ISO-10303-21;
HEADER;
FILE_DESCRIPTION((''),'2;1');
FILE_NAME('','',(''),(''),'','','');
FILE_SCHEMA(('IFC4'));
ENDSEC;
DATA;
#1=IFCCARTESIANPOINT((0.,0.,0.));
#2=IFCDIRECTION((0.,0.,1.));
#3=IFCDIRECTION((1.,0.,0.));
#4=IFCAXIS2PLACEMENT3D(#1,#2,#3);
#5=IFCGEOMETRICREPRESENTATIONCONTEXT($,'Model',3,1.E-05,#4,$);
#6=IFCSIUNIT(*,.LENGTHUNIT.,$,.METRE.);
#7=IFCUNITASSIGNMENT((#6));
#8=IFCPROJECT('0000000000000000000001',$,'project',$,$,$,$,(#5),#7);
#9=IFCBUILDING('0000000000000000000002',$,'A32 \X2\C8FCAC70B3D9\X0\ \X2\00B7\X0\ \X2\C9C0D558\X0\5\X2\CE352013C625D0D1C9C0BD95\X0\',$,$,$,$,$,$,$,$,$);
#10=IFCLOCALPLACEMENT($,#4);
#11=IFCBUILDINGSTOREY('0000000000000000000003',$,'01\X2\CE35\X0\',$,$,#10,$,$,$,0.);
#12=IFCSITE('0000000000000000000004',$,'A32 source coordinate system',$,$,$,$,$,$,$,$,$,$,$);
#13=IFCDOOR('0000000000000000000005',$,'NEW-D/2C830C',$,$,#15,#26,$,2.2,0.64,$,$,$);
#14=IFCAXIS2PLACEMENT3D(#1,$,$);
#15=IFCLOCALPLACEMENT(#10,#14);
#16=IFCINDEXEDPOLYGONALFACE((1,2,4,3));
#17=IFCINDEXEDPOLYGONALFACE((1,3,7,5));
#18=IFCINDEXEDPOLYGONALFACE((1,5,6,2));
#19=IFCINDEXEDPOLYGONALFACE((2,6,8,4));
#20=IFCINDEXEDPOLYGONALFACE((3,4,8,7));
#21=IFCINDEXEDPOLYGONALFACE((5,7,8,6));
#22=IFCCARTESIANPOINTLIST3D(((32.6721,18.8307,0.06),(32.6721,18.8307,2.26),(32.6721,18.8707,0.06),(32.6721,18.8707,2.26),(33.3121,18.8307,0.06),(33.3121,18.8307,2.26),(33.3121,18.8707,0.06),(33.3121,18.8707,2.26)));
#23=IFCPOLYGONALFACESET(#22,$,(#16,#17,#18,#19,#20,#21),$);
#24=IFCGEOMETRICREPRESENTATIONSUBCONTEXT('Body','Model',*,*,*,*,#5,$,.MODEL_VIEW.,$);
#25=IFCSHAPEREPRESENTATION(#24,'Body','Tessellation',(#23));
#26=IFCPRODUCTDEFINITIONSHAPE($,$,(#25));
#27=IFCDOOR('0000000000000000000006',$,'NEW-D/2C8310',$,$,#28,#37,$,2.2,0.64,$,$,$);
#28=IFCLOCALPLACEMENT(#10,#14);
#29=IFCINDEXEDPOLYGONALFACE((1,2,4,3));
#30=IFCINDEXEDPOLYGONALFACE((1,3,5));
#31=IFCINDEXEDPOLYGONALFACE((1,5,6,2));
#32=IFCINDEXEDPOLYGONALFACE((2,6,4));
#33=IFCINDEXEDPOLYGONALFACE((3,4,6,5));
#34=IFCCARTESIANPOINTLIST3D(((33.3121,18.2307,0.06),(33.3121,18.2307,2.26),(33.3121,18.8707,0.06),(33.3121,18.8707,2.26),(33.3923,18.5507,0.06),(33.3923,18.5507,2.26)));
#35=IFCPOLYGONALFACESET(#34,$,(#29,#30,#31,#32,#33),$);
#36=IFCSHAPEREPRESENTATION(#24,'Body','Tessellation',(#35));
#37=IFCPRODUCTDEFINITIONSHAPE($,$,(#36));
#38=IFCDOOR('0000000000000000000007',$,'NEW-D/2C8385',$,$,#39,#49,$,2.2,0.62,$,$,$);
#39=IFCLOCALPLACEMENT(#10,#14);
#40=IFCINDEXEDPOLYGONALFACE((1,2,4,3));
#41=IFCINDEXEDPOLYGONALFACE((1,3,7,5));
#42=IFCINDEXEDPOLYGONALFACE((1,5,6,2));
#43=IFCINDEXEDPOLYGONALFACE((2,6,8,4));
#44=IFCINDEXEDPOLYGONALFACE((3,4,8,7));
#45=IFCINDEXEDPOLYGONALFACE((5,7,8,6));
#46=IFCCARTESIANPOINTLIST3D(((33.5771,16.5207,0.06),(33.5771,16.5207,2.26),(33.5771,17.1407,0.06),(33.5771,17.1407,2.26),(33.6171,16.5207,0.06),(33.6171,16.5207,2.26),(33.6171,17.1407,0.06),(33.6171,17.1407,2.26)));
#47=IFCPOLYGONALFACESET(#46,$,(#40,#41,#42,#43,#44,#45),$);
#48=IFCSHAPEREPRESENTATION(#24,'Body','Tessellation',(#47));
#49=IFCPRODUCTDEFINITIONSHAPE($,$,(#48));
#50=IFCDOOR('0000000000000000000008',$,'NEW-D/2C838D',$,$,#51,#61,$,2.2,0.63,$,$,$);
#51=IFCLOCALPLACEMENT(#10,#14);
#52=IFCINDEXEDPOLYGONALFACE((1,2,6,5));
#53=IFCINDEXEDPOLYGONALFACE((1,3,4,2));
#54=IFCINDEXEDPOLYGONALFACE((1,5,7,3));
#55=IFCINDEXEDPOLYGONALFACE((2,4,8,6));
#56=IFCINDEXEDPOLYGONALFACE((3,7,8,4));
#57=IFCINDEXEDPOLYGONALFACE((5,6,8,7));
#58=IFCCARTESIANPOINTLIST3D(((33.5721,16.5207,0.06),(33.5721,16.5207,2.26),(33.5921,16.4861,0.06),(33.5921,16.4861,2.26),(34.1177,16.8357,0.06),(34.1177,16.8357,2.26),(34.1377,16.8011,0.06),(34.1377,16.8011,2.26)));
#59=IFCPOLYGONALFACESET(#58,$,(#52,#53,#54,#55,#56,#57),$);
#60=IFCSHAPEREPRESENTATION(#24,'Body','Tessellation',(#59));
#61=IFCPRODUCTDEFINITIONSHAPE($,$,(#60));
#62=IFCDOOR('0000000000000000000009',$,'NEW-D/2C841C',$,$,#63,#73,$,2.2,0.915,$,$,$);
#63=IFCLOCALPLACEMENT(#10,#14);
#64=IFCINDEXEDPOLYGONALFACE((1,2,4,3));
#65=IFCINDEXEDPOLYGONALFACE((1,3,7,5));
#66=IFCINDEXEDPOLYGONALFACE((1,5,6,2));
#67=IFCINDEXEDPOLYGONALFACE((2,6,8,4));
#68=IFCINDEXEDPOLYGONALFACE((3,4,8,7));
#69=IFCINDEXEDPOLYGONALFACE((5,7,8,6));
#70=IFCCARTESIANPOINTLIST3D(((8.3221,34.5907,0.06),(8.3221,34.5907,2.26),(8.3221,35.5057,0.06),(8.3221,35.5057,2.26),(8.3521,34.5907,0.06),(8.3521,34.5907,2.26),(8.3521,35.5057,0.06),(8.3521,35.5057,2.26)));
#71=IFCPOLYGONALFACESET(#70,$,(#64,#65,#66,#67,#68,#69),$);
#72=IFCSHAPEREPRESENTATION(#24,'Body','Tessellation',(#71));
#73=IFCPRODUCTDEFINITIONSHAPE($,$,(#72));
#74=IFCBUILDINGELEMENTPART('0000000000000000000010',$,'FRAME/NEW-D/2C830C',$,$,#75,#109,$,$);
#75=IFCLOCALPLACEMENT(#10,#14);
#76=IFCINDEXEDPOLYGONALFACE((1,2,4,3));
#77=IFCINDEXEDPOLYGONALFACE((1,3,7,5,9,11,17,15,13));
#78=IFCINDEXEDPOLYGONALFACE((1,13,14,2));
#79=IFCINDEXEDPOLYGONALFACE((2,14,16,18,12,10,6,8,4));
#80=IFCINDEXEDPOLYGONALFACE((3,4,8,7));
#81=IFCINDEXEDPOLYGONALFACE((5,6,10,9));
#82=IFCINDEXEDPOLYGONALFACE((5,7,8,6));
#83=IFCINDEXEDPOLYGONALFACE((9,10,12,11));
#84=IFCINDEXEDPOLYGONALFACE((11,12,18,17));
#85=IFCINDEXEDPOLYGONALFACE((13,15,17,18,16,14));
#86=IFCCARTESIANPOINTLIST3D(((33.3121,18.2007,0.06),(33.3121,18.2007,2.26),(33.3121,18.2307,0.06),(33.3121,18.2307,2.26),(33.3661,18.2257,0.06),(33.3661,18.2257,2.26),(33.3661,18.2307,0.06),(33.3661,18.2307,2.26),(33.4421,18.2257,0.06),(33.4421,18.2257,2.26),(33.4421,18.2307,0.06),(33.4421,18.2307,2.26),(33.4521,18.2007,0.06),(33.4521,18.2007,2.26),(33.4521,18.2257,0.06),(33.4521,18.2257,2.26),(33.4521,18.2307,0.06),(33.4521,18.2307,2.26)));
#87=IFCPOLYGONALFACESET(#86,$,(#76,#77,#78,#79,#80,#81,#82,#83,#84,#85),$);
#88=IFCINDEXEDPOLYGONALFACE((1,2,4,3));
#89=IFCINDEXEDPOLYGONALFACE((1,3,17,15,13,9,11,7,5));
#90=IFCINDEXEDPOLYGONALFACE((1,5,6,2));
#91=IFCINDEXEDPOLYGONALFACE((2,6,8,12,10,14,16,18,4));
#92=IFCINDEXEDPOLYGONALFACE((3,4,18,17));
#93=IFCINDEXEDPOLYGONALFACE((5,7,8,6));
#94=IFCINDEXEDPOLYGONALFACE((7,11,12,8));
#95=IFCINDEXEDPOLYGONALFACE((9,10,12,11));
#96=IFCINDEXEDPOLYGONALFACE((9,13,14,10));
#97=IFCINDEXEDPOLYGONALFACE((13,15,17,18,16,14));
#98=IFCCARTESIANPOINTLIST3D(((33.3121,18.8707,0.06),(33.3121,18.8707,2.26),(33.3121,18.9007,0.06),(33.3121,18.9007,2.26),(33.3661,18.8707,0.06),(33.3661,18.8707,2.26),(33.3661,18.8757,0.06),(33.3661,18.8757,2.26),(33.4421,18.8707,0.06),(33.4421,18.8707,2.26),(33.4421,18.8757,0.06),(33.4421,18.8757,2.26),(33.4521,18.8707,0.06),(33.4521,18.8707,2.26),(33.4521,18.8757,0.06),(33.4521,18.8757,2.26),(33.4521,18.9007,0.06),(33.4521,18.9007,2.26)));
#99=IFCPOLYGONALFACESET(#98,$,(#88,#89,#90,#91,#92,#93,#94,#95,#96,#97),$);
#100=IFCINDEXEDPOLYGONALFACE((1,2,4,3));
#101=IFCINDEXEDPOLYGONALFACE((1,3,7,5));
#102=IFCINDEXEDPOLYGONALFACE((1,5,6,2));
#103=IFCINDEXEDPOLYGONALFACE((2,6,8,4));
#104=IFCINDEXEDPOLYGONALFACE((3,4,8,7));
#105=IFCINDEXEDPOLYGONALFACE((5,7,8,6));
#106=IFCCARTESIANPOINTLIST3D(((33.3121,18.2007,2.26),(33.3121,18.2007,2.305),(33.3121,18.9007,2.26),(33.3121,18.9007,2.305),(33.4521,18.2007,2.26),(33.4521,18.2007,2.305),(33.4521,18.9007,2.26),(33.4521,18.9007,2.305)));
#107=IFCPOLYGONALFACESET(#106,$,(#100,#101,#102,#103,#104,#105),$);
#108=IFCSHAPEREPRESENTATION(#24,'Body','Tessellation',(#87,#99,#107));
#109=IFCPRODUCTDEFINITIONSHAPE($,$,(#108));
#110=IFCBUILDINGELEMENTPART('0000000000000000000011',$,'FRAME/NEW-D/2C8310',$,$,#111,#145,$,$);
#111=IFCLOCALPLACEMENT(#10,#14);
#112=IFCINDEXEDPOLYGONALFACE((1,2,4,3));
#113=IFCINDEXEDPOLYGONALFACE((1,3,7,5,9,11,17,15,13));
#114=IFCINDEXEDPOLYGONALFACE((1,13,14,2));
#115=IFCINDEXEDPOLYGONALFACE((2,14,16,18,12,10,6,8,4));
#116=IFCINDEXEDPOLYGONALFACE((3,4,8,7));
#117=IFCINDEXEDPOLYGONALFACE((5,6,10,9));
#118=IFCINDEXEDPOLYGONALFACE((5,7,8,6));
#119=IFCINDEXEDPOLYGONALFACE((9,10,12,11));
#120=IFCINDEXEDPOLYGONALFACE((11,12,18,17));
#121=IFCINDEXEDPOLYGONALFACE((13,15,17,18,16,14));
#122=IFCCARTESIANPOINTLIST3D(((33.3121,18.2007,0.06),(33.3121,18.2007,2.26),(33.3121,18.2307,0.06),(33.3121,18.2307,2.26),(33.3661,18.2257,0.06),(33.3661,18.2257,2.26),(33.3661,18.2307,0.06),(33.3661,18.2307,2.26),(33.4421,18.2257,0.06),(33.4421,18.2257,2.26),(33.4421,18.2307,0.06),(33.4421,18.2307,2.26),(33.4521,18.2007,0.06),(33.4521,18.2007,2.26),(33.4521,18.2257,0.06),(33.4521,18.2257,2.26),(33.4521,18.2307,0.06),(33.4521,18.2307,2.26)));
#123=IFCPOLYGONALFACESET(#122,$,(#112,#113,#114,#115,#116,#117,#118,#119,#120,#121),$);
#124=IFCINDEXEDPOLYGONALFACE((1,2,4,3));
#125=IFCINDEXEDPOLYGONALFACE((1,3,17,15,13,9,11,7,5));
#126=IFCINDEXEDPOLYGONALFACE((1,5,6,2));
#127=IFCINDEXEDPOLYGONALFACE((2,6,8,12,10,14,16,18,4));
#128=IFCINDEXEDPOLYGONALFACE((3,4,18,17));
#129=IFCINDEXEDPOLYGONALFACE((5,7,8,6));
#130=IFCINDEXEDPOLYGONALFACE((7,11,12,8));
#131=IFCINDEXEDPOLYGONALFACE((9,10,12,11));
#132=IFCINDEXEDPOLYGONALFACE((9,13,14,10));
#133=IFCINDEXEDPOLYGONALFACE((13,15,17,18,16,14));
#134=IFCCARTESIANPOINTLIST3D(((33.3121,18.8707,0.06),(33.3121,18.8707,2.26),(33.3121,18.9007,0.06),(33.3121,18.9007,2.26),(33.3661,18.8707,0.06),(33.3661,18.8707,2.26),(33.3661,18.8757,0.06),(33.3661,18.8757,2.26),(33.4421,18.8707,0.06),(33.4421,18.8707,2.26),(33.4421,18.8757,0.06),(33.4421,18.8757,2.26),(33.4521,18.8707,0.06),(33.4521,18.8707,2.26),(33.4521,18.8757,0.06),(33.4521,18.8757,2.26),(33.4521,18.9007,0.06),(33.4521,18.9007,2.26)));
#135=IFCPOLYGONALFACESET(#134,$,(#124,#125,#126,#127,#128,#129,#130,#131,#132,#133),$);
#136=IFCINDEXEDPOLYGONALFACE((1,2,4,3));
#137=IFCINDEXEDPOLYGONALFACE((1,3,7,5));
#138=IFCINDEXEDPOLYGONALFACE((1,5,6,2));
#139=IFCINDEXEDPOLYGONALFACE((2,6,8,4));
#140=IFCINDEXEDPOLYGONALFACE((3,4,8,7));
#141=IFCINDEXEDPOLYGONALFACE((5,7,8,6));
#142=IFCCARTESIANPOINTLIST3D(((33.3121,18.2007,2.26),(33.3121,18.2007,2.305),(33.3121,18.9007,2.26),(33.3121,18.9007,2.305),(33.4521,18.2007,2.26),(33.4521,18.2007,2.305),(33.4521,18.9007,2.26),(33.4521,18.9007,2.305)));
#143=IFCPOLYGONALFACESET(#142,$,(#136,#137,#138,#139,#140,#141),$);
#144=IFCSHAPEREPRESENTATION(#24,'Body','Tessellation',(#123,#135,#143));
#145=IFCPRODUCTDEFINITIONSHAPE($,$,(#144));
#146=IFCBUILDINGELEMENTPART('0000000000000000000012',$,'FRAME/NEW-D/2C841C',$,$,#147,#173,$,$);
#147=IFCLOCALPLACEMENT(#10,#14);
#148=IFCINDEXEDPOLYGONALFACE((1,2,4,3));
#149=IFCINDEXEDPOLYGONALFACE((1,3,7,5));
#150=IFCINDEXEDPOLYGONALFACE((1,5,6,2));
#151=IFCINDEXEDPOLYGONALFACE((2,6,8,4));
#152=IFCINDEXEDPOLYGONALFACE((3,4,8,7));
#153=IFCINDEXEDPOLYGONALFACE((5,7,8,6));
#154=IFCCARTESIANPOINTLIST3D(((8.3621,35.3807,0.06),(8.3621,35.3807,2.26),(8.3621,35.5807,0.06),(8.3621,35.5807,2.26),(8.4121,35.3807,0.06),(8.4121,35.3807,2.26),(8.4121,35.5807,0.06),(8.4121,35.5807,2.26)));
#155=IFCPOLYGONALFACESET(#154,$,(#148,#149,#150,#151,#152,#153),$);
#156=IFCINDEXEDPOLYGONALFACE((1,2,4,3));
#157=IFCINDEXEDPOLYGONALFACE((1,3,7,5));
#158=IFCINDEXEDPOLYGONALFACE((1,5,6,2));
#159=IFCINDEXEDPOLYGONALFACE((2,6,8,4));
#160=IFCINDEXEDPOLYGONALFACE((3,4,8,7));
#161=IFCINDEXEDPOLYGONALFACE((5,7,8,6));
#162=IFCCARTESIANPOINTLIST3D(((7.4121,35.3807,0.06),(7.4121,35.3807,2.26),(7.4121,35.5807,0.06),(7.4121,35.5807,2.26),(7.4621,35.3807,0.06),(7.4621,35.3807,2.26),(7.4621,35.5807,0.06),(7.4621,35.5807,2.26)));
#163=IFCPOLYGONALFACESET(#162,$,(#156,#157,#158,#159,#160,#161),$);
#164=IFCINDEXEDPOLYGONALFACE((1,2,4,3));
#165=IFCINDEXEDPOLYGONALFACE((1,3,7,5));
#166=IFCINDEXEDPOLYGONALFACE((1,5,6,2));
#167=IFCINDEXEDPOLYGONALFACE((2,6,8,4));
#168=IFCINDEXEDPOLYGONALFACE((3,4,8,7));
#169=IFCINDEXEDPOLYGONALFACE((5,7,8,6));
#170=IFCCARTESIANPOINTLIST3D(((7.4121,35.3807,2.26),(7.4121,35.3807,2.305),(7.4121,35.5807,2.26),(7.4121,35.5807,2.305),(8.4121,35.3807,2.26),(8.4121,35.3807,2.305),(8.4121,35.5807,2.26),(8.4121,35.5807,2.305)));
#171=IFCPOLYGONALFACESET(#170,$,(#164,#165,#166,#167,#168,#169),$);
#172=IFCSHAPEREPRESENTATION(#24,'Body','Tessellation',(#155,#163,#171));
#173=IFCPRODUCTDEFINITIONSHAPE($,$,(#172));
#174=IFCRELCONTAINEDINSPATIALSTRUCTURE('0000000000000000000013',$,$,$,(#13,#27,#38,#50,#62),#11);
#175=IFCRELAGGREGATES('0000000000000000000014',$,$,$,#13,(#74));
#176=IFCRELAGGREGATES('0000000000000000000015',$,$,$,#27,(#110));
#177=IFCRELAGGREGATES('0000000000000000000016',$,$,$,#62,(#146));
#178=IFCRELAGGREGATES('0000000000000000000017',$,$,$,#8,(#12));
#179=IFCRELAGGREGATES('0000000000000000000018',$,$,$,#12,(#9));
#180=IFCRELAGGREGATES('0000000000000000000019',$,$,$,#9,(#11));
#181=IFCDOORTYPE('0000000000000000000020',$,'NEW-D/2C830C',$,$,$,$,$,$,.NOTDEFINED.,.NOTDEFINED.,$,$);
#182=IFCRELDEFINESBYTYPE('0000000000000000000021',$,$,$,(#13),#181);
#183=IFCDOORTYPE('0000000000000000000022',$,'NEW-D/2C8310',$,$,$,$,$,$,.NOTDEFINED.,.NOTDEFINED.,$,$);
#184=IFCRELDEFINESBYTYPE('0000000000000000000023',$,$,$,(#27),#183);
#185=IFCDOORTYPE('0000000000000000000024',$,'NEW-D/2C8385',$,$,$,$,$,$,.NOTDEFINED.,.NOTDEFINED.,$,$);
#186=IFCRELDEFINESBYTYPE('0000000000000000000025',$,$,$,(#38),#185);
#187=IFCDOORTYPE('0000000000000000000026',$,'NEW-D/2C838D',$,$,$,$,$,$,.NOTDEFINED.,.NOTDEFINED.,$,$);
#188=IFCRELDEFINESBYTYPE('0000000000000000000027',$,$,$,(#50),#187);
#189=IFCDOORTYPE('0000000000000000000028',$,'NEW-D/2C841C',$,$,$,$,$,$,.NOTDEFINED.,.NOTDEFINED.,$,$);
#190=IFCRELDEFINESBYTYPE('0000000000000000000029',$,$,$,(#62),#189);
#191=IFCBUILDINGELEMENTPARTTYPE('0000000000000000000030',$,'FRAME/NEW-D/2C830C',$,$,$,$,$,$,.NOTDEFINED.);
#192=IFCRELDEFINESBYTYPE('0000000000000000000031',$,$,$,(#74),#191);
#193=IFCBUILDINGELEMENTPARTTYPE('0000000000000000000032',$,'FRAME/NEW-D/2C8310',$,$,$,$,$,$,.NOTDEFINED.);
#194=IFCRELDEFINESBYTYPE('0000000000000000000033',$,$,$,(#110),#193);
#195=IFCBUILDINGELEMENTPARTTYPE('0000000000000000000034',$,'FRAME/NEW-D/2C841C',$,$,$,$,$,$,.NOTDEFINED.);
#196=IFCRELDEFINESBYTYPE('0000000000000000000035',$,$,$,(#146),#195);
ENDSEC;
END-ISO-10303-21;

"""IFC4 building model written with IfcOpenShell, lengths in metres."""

from ifc_helpers import new_model, si_unit, frame, origin, origin_with_axes, place, context, subcontext, project, spatial, polyline, outline, extrude, source, transform, mapped, type_object, type_shapes, element, aggregate, save


model = new_model("IFC4")

# Units and contexts
model_context = context("Model", 3, precision=1e-05, world=origin_with_axes())
body_context = subcontext(model_context, "Body", "Model", "MODEL_VIEW")
ifc_project = project(units=[si_unit("LENGTHUNIT", "METRE")], contexts=[model_context])

# Site, building, storey
site = spatial("IfcSite", under=ifc_project, Name="A32 source coordinate system")
building = spatial("IfcBuilding", under=site, Name="A32 주거동 · 지하5층–옥탑지붕")
storey_placement = place(None, origin_with_axes())
storey = spatial("IfcBuildingStorey", under=building, at=storey_placement, Name="01층", Elevation=0.0)

# Doors
door_type_1 = type_object("IfcDoorType", Name="NEW-D/2C830C", OperationType="NOTDEFINED", PredefinedType="NOTDEFINED")
shared_shape_1 = source(origin(), body_context, "Body", "SweptSolid", [
    extrude(outline(polyline([(33.3121, 18.8707), (33.3121, 18.8307), (32.6721, 18.8307), (32.6721, 18.8707), (33.3121, 18.8707)])), frame((0.0, 0.0, 0.06)), (0.0, 0.0, 1.0), 2.2),
])
type_shapes(door_type_1, [shared_shape_1])
door_1_placement = place(storey_placement, origin_with_axes())
door_1 = element("IfcDoor", 1, at=door_1_placement, inside=storey, type_object=door_type_1, Name="NEW-D/2C830C", OverallHeight=2.2, OverallWidth=0.64, context=body_context, shape_type="MappedRepresentation", body=[
    mapped(shared_shape_1, transform((0.0, 0.0, 0.0), scale=1.0)),
])
door_type_2 = type_object("IfcDoorType", Name="NEW-D/2C8310", OperationType="NOTDEFINED", PredefinedType="NOTDEFINED")
shared_shape_2 = source(origin(), body_context, "Body", "SweptSolid", [
    extrude(outline(polyline([(33.3121, 18.2307), (33.3121, 18.8707), (33.3923, 18.5507), (33.3121, 18.2307)])), frame((0.0, 0.0, 0.06)), (0.0, 0.0, 1.0), 2.2),
])
type_shapes(door_type_2, [shared_shape_2])
door_2_placement = place(storey_placement, origin_with_axes())
door_2 = element("IfcDoor", 2, at=door_2_placement, inside=storey, type_object=door_type_2, Name="NEW-D/2C8310", OverallHeight=2.2, OverallWidth=0.64, context=body_context, shape_type="MappedRepresentation", body=[
    mapped(shared_shape_2, transform((0.0, 0.0, 0.0), scale=1.0)),
])

# Doors
door_type_3 = type_object("IfcDoorType", Name="NEW-D/2C8385", OperationType="NOTDEFINED", PredefinedType="NOTDEFINED")
shared_shape_3 = source(origin(), body_context, "Body", "SweptSolid", [
    extrude(outline(polyline([(33.6171, 17.1407), (33.6171, 16.5207), (33.5771, 16.5207), (33.5771, 17.1407), (33.6171, 17.1407)])), frame((0.0, 0.0, 0.06)), (0.0, 0.0, 1.0), 2.2),
])
type_shapes(door_type_3, [shared_shape_3])
door_3_placement = place(storey_placement, origin_with_axes())
element("IfcDoor", 3, at=door_3_placement, inside=storey, type_object=door_type_3, Name="NEW-D/2C8385", OverallHeight=2.2, OverallWidth=0.62, context=body_context, shape_type="MappedRepresentation", body=[
    mapped(shared_shape_3, transform((0.0, 0.0, 0.0), scale=1.0)),
])
door_type_4 = type_object("IfcDoorType", Name="NEW-D/2C838D", OperationType="NOTDEFINED", PredefinedType="NOTDEFINED")
shared_shape_4 = source(origin(), body_context, "Body", "SweptSolid", [
    extrude(outline(polyline([(34.1377, 16.8011), (33.5921, 16.4861), (33.5721, 16.5207), (34.1177, 16.8357), (34.1377, 16.8011)])), frame((0.0, 0.0, 0.06)), (0.0, 0.0, 1.0), 2.2),
])
type_shapes(door_type_4, [shared_shape_4])
door_4_placement = place(storey_placement, origin_with_axes())
element("IfcDoor", 4, at=door_4_placement, inside=storey, type_object=door_type_4, Name="NEW-D/2C838D", OverallHeight=2.2, OverallWidth=0.63, context=body_context, shape_type="MappedRepresentation", body=[
    mapped(shared_shape_4, transform((0.0, 0.0, 0.0), scale=1.0)),
])

# Door
door_type_5 = type_object("IfcDoorType", Name="NEW-D/2C841C", OperationType="NOTDEFINED", PredefinedType="NOTDEFINED")
shared_shape_5 = source(origin(), body_context, "Body", "SweptSolid", [
    extrude(outline(polyline([(8.3521, 34.5907), (8.3221, 34.5907), (8.3221, 35.5057), (8.3521, 35.5057), (8.3521, 34.5907)])), frame((0.0, 0.0, 0.06)), (0.0, 0.0, 1.0), 2.2),
])
type_shapes(door_type_5, [shared_shape_5])
door_5_placement = place(storey_placement, origin_with_axes())
door_5 = element("IfcDoor", 5, at=door_5_placement, inside=storey, type_object=door_type_5, Name="NEW-D/2C841C", OverallHeight=2.2, OverallWidth=0.915, context=body_context, shape_type="MappedRepresentation", body=[
    mapped(shared_shape_5, transform((0.0, 0.0, 0.0), scale=1.0)),
])

# Building element parts
building_element_part_type_1 = type_object("IfcBuildingElementPartType", Name="FRAME/NEW-D/2C830C", PredefinedType="NOTDEFINED")
shared_shape_6 = source(origin(), body_context, "Body", "SweptSolid", [
    extrude(outline(polyline([(33.3121, 18.2007), (33.3121, 18.2307), (33.3661, 18.2307), (33.3661, 18.2257), (33.4421, 18.2257), (33.4421, 18.2307), (33.4521, 18.2307), (33.4521, 18.2257), (33.4521, 18.2007), (33.3121, 18.2007)])), frame((0.0, 0.0, 0.06)), (0.0, 0.0, 1.0), 2.2),
    extrude(outline(polyline([(33.4421, 18.8707), (33.4421, 18.8757), (33.3661, 18.8757), (33.3661, 18.8707), (33.3121, 18.8707), (33.3121, 18.9007), (33.4521, 18.9007), (33.4521, 18.8757), (33.4521, 18.8707), (33.4421, 18.8707)])), frame((0.0, 0.0, 0.06)), (0.0, 0.0, 1.0), 2.2),
    extrude(outline(polyline([(33.4521, 18.2007), (33.4521, 18.9007), (33.3121, 18.9007), (33.3121, 18.2007), (33.4521, 18.2007)])), frame((0.0, 0.0, 2.26)), (0.0, 0.0, 1.0), 0.045),
])
type_shapes(building_element_part_type_1, [shared_shape_6])
building_element_part_1_placement = place(door_1_placement, origin_with_axes())
building_element_part_1 = element("IfcBuildingElementPart", 6, at=building_element_part_1_placement, type_object=building_element_part_type_1, Name="FRAME/NEW-D/2C830C", context=body_context, shape_type="MappedRepresentation", body=[
    mapped(shared_shape_6, transform((0.0, 0.0, 0.0), scale=1.0)),
])
aggregate(door_1, [building_element_part_1])
building_element_part_type_2 = type_object("IfcBuildingElementPartType", Name="FRAME/NEW-D/2C8310", PredefinedType="NOTDEFINED")
shared_shape_7 = source(origin(), body_context, "Body", "SweptSolid", [
    extrude(outline(polyline([(33.3121, 18.2007), (33.3121, 18.2307), (33.3661, 18.2307), (33.3661, 18.2257), (33.4421, 18.2257), (33.4421, 18.2307), (33.4521, 18.2307), (33.4521, 18.2257), (33.4521, 18.2007), (33.3121, 18.2007)])), frame((0.0, 0.0, 0.06)), (0.0, 0.0, 1.0), 2.2),
    extrude(outline(polyline([(33.4421, 18.8707), (33.4421, 18.8757), (33.3661, 18.8757), (33.3661, 18.8707), (33.3121, 18.8707), (33.3121, 18.9007), (33.4521, 18.9007), (33.4521, 18.8757), (33.4521, 18.8707), (33.4421, 18.8707)])), frame((0.0, 0.0, 0.06)), (0.0, 0.0, 1.0), 2.2),
    extrude(outline(polyline([(33.4521, 18.2007), (33.4521, 18.9007), (33.3121, 18.9007), (33.3121, 18.2007), (33.4521, 18.2007)])), frame((0.0, 0.0, 2.26)), (0.0, 0.0, 1.0), 0.045),
])
type_shapes(building_element_part_type_2, [shared_shape_7])
building_element_part_2_placement = place(door_2_placement, origin_with_axes())
building_element_part_2 = element("IfcBuildingElementPart", 7, at=building_element_part_2_placement, type_object=building_element_part_type_2, Name="FRAME/NEW-D/2C8310", context=body_context, shape_type="MappedRepresentation", body=[
    mapped(shared_shape_7, transform((0.0, 0.0, 0.0), scale=1.0)),
])
aggregate(door_2, [building_element_part_2])
building_element_part_type_3 = type_object("IfcBuildingElementPartType", Name="FRAME/NEW-D/2C841C", PredefinedType="NOTDEFINED")
shared_shape_8 = source(origin(), body_context, "Body", "SweptSolid", [
    extrude(outline(polyline([(8.3621, 35.5807), (8.4121, 35.5807), (8.4121, 35.3807), (8.3621, 35.3807), (8.3621, 35.5807)])), frame((0.0, 0.0, 0.06)), (0.0, 0.0, 1.0), 2.2),
    extrude(outline(polyline([(7.4121, 35.5807), (7.4621, 35.5807), (7.4621, 35.3807), (7.4121, 35.3807), (7.4121, 35.5807)])), frame((0.0, 0.0, 0.06)), (0.0, 0.0, 1.0), 2.2),
    extrude(outline(polyline([(8.4121, 35.3807), (8.4121, 35.5807), (7.4121, 35.5807), (7.4121, 35.3807), (8.4121, 35.3807)])), frame((0.0, 0.0, 2.26)), (0.0, 0.0, 1.0), 0.045),
])
type_shapes(building_element_part_type_3, [shared_shape_8])
building_element_part_3_placement = place(door_5_placement, origin_with_axes())
building_element_part_3 = element("IfcBuildingElementPart", 8, at=building_element_part_3_placement, type_object=building_element_part_type_3, Name="FRAME/NEW-D/2C841C", context=body_context, shape_type="MappedRepresentation", body=[
    mapped(shared_shape_8, transform((0.0, 0.0, 0.0), scale=1.0)),
])
aggregate(door_5, [building_element_part_3])

save(model, "model.ifc")
